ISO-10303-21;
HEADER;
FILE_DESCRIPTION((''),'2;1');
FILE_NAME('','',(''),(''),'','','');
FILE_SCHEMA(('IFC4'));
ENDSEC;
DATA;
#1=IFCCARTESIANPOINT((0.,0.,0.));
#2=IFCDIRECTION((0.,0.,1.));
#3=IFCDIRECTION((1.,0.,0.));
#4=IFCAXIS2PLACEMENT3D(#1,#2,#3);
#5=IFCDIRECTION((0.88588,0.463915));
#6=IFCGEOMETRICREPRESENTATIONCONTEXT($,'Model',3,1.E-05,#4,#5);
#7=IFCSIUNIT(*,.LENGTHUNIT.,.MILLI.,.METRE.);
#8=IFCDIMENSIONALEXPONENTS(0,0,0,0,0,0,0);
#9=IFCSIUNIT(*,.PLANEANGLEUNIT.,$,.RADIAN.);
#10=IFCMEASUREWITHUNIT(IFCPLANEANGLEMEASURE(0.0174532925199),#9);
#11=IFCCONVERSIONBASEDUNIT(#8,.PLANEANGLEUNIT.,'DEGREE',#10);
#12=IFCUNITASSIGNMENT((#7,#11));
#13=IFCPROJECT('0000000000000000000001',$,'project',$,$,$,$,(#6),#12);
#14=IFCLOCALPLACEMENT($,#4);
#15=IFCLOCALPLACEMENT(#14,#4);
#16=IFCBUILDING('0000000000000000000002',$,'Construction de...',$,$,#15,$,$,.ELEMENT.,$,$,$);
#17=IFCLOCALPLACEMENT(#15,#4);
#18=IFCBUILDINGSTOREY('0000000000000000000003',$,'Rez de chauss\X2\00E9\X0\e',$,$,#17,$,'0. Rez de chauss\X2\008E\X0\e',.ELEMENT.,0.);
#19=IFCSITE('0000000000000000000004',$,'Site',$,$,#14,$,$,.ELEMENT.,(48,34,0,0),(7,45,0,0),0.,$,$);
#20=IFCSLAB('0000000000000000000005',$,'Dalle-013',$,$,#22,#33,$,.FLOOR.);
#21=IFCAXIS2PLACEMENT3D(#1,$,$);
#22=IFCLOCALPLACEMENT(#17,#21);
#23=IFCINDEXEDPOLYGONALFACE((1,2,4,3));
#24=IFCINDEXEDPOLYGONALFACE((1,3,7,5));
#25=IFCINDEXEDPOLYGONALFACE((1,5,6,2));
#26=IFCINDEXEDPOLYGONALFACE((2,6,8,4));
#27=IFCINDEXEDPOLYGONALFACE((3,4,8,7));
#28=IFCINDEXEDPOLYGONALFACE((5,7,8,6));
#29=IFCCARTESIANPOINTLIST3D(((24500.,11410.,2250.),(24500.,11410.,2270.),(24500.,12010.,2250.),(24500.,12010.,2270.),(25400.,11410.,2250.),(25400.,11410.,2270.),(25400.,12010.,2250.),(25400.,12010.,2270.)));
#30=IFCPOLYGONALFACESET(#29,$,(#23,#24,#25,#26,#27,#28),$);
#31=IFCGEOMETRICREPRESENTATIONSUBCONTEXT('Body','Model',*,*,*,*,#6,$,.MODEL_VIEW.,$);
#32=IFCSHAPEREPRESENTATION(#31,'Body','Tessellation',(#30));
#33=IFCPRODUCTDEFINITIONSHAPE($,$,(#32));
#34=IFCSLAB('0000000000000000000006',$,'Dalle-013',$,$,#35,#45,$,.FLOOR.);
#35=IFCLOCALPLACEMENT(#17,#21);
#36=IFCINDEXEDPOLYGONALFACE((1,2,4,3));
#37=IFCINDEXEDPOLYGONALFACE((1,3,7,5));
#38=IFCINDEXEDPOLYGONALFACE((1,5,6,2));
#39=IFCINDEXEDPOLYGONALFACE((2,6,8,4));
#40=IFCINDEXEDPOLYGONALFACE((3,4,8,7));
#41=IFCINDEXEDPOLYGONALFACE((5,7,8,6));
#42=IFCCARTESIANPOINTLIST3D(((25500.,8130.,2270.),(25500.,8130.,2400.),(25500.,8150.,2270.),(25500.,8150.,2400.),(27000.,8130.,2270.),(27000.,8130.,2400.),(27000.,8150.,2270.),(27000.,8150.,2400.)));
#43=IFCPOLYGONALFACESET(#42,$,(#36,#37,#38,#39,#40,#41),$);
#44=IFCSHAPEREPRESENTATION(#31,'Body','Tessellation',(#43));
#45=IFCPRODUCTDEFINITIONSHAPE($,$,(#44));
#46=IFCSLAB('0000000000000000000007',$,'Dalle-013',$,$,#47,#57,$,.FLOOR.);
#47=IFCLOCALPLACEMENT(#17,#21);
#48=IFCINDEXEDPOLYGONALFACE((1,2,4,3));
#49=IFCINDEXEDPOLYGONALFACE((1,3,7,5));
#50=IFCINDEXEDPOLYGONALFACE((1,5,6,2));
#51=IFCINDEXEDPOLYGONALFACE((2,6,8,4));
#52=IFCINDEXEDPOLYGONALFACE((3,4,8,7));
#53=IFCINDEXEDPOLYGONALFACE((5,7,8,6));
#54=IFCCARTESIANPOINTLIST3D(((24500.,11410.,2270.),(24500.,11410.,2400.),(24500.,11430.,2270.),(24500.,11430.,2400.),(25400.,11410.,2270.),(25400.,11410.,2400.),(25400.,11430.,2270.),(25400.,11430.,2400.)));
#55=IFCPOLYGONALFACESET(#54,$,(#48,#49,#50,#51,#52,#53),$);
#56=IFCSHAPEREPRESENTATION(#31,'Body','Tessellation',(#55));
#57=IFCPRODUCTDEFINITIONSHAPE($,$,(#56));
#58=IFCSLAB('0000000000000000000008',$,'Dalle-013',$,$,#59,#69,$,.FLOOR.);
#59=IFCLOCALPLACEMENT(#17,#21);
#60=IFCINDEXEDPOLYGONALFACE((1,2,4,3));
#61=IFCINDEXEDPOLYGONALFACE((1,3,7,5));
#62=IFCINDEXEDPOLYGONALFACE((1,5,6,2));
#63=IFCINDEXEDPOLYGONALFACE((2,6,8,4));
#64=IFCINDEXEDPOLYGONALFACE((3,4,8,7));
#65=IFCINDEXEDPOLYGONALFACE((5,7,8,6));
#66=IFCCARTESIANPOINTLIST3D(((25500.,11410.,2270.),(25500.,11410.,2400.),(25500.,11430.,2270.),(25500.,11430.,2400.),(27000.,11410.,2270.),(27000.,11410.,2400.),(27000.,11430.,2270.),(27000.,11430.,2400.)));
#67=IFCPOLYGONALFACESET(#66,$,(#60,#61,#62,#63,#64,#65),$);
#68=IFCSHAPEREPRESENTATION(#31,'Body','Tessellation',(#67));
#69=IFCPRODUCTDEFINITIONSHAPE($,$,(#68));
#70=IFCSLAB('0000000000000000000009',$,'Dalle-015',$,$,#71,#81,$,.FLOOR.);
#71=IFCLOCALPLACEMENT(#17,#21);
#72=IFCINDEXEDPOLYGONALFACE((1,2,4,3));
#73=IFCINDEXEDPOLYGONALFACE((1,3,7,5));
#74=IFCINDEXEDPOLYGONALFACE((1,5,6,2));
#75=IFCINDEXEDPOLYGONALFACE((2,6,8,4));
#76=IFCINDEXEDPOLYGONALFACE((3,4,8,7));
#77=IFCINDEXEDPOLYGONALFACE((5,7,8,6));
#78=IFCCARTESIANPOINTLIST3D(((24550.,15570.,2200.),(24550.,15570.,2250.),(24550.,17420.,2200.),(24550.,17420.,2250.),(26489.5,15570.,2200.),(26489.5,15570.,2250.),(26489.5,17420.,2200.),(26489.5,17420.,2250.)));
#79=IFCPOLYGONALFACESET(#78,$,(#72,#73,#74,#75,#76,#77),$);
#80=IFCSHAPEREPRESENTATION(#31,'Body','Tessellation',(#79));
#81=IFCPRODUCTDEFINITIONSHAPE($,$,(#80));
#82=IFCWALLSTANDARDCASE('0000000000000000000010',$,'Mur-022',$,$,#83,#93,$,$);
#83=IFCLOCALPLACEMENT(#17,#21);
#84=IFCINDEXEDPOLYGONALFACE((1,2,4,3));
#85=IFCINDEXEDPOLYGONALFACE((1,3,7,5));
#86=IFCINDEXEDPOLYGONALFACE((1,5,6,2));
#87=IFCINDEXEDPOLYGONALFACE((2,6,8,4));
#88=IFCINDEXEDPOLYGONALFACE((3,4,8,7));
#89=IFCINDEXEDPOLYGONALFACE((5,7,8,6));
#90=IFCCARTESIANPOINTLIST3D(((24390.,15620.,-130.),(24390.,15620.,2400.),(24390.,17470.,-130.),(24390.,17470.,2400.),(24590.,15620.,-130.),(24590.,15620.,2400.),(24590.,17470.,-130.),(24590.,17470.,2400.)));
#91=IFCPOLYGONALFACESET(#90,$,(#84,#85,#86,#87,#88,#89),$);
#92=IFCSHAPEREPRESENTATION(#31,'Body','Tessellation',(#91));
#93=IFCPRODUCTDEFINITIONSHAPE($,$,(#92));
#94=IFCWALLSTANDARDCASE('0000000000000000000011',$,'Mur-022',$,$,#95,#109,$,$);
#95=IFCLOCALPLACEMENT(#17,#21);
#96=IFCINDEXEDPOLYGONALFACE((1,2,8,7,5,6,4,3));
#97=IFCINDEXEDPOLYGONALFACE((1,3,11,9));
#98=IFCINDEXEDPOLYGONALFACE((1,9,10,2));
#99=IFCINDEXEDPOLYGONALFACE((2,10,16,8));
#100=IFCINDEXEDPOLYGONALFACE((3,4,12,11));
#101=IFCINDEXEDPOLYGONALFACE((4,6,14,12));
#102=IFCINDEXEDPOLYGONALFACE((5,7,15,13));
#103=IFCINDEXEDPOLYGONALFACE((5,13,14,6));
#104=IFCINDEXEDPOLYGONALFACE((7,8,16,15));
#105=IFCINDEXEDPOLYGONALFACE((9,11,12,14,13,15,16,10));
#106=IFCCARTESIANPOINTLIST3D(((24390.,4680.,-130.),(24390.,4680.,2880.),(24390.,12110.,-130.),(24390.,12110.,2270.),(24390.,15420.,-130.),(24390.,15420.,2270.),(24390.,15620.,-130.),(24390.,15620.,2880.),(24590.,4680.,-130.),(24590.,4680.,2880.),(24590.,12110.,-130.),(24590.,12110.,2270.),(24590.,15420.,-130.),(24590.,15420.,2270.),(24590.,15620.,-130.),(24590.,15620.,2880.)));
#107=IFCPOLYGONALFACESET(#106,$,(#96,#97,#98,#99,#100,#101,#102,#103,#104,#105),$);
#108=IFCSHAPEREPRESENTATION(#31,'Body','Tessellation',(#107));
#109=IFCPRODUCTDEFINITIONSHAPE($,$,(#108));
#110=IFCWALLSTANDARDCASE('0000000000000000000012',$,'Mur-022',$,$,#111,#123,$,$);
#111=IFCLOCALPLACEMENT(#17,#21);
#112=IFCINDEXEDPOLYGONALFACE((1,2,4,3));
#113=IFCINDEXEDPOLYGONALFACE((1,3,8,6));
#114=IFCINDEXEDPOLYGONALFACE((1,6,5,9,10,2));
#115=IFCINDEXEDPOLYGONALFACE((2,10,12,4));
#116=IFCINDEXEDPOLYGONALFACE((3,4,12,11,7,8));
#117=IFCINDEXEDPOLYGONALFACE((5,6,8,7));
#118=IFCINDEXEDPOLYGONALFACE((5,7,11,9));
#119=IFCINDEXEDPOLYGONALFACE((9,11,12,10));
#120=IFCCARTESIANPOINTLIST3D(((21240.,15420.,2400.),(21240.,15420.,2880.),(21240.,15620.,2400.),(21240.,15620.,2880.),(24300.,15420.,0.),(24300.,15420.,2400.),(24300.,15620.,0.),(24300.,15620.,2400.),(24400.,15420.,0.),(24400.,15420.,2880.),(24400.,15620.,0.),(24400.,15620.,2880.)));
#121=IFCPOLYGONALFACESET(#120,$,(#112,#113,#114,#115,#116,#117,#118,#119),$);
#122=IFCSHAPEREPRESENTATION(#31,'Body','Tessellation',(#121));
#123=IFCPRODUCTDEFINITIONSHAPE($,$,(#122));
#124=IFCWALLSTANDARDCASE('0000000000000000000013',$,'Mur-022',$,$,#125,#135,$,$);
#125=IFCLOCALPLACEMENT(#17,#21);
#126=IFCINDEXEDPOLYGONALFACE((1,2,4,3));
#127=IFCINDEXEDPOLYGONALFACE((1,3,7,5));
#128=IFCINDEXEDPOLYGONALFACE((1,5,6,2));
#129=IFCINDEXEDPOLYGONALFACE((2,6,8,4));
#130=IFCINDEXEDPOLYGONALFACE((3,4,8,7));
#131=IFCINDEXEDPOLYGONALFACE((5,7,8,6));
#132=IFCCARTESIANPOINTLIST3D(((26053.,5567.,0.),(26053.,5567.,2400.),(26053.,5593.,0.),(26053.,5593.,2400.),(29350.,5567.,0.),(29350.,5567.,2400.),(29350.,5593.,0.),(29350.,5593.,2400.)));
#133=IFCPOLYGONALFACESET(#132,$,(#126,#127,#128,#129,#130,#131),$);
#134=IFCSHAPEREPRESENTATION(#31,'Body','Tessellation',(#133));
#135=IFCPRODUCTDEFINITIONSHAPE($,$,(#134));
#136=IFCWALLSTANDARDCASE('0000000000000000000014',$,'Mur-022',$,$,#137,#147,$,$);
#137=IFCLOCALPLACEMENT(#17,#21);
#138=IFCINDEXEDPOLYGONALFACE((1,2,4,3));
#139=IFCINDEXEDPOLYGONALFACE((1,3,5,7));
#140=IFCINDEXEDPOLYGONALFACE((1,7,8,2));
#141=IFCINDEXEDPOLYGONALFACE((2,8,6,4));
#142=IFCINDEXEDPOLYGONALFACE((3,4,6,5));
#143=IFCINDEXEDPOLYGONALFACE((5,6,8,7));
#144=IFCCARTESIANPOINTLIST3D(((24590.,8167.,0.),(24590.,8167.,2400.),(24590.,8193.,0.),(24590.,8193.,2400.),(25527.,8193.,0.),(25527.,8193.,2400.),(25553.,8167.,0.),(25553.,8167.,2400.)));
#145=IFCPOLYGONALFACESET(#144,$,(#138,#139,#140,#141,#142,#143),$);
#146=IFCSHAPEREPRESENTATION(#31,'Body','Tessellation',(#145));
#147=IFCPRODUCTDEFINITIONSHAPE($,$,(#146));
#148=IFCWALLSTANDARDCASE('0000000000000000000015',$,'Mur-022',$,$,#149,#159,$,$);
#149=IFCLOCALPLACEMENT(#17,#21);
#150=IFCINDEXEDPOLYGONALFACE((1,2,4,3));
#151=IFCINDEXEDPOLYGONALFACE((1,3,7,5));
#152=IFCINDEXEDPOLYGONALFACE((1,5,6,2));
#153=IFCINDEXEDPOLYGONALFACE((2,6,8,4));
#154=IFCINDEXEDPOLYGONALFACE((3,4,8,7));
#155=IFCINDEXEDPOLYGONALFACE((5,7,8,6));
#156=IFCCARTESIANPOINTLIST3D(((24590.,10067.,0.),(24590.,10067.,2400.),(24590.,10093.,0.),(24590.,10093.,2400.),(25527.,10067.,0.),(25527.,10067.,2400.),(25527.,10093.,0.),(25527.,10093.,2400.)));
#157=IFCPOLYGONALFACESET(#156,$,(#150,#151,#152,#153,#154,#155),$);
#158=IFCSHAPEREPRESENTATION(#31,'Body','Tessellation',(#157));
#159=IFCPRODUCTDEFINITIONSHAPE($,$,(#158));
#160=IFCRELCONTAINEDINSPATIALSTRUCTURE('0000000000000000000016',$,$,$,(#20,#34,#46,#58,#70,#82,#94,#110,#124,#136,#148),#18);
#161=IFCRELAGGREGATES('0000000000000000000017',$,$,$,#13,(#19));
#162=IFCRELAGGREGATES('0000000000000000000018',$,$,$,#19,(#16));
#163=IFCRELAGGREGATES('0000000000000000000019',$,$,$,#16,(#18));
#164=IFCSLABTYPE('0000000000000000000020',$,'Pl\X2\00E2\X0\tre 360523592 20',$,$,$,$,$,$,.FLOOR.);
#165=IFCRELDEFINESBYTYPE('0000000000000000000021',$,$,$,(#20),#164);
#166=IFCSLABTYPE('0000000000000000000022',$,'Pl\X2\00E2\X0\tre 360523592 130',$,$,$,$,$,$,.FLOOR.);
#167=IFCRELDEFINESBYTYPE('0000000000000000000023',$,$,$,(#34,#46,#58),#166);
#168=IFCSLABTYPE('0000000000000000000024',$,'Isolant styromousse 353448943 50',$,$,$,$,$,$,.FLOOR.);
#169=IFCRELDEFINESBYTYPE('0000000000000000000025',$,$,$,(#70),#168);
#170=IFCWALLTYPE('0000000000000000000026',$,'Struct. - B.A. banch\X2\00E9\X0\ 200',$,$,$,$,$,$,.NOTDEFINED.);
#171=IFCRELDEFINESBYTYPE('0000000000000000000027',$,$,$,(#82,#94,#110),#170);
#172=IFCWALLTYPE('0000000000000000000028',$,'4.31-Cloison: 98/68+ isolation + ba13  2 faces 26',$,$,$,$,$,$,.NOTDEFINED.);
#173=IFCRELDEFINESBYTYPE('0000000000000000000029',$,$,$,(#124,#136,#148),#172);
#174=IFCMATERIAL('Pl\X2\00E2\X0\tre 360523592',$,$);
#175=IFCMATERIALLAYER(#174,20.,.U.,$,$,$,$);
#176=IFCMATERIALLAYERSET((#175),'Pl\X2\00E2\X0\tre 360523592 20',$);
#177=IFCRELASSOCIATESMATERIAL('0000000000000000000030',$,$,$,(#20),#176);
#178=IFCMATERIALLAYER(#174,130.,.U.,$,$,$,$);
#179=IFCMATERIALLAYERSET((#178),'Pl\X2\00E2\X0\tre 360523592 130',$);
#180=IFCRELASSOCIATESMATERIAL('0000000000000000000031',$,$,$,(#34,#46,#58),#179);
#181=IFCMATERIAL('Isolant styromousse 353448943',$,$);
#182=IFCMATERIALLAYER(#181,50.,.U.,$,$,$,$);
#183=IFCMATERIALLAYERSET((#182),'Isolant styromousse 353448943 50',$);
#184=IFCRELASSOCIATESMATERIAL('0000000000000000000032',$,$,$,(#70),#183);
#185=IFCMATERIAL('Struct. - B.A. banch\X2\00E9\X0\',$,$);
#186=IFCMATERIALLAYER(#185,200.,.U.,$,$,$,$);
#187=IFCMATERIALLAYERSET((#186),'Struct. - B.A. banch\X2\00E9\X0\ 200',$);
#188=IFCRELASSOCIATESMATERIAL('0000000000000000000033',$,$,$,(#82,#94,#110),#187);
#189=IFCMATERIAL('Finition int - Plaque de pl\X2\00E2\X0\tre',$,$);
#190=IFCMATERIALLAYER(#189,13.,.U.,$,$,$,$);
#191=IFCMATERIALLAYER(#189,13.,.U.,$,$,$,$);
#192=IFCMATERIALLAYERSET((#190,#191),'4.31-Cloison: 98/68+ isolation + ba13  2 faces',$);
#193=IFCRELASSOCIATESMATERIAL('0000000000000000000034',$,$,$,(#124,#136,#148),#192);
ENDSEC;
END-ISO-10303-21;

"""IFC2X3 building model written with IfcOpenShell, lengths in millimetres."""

from ifc_helpers import new_model, entity, si_unit, converted_unit, direction, frame, origin_with_axes, origin_2d_with_axis, place, context, subcontext, project, spatial, polyline, rectangle, outline, extrude, material, layer, layer_set, layer_usage, type_object, element, save


model = new_model("IFC2X3")

# Units and contexts
model_context = context("Model", 3, precision=1e-05, world=origin_with_axes(), true_north=direction((0.88588, 0.463915)))
body_context = subcontext(model_context, "Body", "Model", "MODEL_VIEW")
ifc_project = project(units=[si_unit("LENGTHUNIT", "METRE", prefix="MILLI"), converted_unit("PLANEANGLEUNIT", "DEGREE", entity("IfcPlaneAngleMeasure", 0.0174532925199), si_unit("PLANEANGLEUNIT", "RADIAN"), dimensions=[0, 0, 0, 0, 0, 0, 0])], contexts=[model_context])

# Site, building, storey
site_placement = place(None, origin_with_axes())
site = spatial("IfcSite", under=ifc_project, at=site_placement, Name="Site", CompositionType="ELEMENT", RefLatitude=(48, 34, 0, 0), RefLongitude=(7, 45, 0, 0), RefElevation=0.0)
building_placement = place(site_placement, origin_with_axes())
building = spatial("IfcBuilding", under=site, at=building_placement, Name="Construction de...", CompositionType="ELEMENT")
storey_placement = place(building_placement, origin_with_axes())
storey = spatial("IfcBuildingStorey", under=building, at=storey_placement, Name="Rez de chaussée", LongName="0. Rez de chauss\u008ee", CompositionType="ELEMENT", Elevation=0.0)

# Shared definitions
ifc_material_1 = material(Name="Plâtre 360523592")
ifc_layer_1 = layer(ifc_material_1, 20.0, ventilated="UNKNOWN")
ifc_layer_set_1 = layer_set([ifc_layer_1], Name="Plâtre 360523592 20")
slab_type_1 = type_object("IfcSlabType", Name="Plâtre 360523592 20", PredefinedType="FLOOR")

# Slabs
ifc_layer_usage_1 = layer_usage(ifc_layer_set_1, "AXIS3", "NEGATIVE", 20.0)
slab_1_placement = place(storey_placement, frame((25400.0, 12010.0, 2270.0), z_axis=(0.0, 0.0, 1.0), x_axis=(1.0, 0.0, 0.0)))
element("IfcSlab", 1, at=slab_1_placement, inside=storey, type_object=slab_type_1, material=ifc_layer_usage_1, Name="Dalle-013", PredefinedType="FLOOR", context=body_context, shape_type="SweptSolid", body=[
    extrude(outline(polyline([(0.0, 0.0), (-900.0, 0.0), (-900.0, -600.0), (0.0, -600.0), (0.0, 0.0)])), frame((0.0, 0.0, -20.0), z_axis=(0.0, 0.0, 1.0), x_axis=(1.0, 0.0, 0.0)), (0.0, 0.0, 1.0), 20.0),
])
ifc_layer_2 = layer(ifc_material_1, 130.0, ventilated="UNKNOWN")
ifc_layer_set_2 = layer_set([ifc_layer_2], Name="Plâtre 360523592 130")
ifc_layer_usage_2 = layer_usage(ifc_layer_set_2, "AXIS3", "NEGATIVE", 130.0)
slab_type_2 = type_object("IfcSlabType", Name="Plâtre 360523592 130", PredefinedType="FLOOR")
slab_2_placement = place(storey_placement, frame((25500.0, 8150.0, 2400.0), z_axis=(0.0, 0.0, 1.0), x_axis=(1.0, 0.0, 0.0)))
element("IfcSlab", 2, at=slab_2_placement, inside=storey, type_object=slab_type_2, material=ifc_layer_usage_2, Name="Dalle-013", PredefinedType="FLOOR", context=body_context, shape_type="SweptSolid", body=[
    extrude(outline(polyline([(0.0, 0.0), (0.0, -20.0), (1500.0, -20.0), (1500.0, 0.0), (0.0, 0.0)])), frame((0.0, 0.0, -130.0), z_axis=(0.0, 0.0, 1.0), x_axis=(1.0, 0.0, 0.0)), (0.0, 0.0, 1.0), 130.0),
])
ifc_layer_usage_3 = layer_usage(ifc_layer_set_2, "AXIS3", "NEGATIVE", 130.0)
slab_3_placement = place(storey_placement, frame((24500.0, 11430.0, 2400.0), z_axis=(0.0, 0.0, 1.0), x_axis=(1.0, 0.0, 0.0)))
element("IfcSlab", 3, at=slab_3_placement, inside=storey, type_object=slab_type_2, material=ifc_layer_usage_3, Name="Dalle-013", PredefinedType="FLOOR", context=body_context, shape_type="SweptSolid", body=[
    extrude(outline(polyline([(0.0, 0.0), (0.0, -20.0), (900.0, -20.0), (900.0, 0.0), (0.0, 0.0)])), frame((0.0, 0.0, -130.0), z_axis=(0.0, 0.0, 1.0), x_axis=(1.0, 0.0, 0.0)), (0.0, 0.0, 1.0), 130.0),
])
ifc_layer_usage_4 = layer_usage(ifc_layer_set_2, "AXIS3", "NEGATIVE", 130.0)
slab_4_placement = place(storey_placement, frame((25500.0, 11430.0, 2400.0), z_axis=(0.0, 0.0, 1.0), x_axis=(1.0, 0.0, 0.0)))
element("IfcSlab", 4, at=slab_4_placement, inside=storey, type_object=slab_type_2, material=ifc_layer_usage_4, Name="Dalle-013", PredefinedType="FLOOR", context=body_context, shape_type="SweptSolid", body=[
    extrude(outline(polyline([(0.0, 0.0), (0.0, -20.0), (1500.0, -20.0), (1500.0, 0.0), (0.0, 0.0)])), frame((0.0, 0.0, -130.0), z_axis=(0.0, 0.0, 1.0), x_axis=(1.0, 0.0, 0.0)), (0.0, 0.0, 1.0), 130.0),
])
ifc_material_2 = material(Name="Isolant styromousse 353448943")
ifc_layer_3 = layer(ifc_material_2, 50.0, ventilated="UNKNOWN")
ifc_layer_set_3 = layer_set([ifc_layer_3], Name="Isolant styromousse 353448943 50")
ifc_layer_usage_5 = layer_usage(ifc_layer_set_3, "AXIS3", "NEGATIVE", 50.0)
slab_type_3 = type_object("IfcSlabType", Name="Isolant styromousse 353448943 50", PredefinedType="FLOOR")
slab_5_placement = place(storey_placement, frame((24550.0, 17420.0, 2250.0), z_axis=(0.0, 0.0, 1.0), x_axis=(1.0, 0.0, 0.0)))
element("IfcSlab", 5, at=slab_5_placement, inside=storey, type_object=slab_type_3, material=ifc_layer_usage_5, Name="Dalle-015", PredefinedType="FLOOR", context=body_context, shape_type="SweptSolid", body=[
    extrude(outline(polyline([(0.0, 0.0), (0.0, -1850.0), (1939.5, -1850.0), (1939.5, 0.0), (0.0, 0.0)])), frame((0.0, 0.0, -50.0), z_axis=(0.0, 0.0, 1.0), x_axis=(1.0, 0.0, 0.0)), (0.0, 0.0, 1.0), 50.0),
])

# Wall
ifc_material_3 = material(Name="Struct. - B.A. banché")
ifc_layer_4 = layer(ifc_material_3, 200.0, ventilated="UNKNOWN")
ifc_layer_set_4 = layer_set([ifc_layer_4], Name="Struct. - B.A. banché 200")
ifc_layer_usage_6 = layer_usage(ifc_layer_set_4, "AXIS2", "POSITIVE", -100.0)
wall_type_1 = type_object("IfcWallType", Name="Struct. - B.A. banché 200", PredefinedType="NOTDEFINED")
wall_1_placement = place(storey_placement, frame((24490.0, 17470.0, -130.0), z_axis=(0.0, 0.0, 1.0), x_axis=(0.0, -1.0, 0.0)))
element("IfcWallStandardCase", 6, at=wall_1_placement, inside=storey, type_object=wall_type_1, material=ifc_layer_usage_6, Name="Mur-022", context=body_context, shape_type="SweptSolid", body=[
    extrude(outline(polyline([(0.0, -100.0), (1850.0, -100.0), (1850.0, 100.0), (0.0, 100.0), (0.0, -100.0)])), origin_with_axes(), (0.0, 0.0, 1.0), 2530.0),
])

# Walls, openings
ifc_layer_usage_7 = layer_usage(ifc_layer_set_4, "AXIS2", "POSITIVE", -100.0)
wall_2_placement = place(storey_placement, frame((24490.0, 15620.0, -130.0), z_axis=(0.0, 0.0, 1.0), x_axis=(0.0, -1.0, 0.0)))
wall_2 = element("IfcWallStandardCase", 7, at=wall_2_placement, inside=storey, type_object=wall_type_1, material=ifc_layer_usage_7, Name="Mur-022", context=body_context, shape_type="SweptSolid", body=[
    extrude(outline(polyline([(0.0, -100.0), (10940.0, -100.0), (10940.0, 100.0), (0.0, 100.0), (0.0, -100.0)])), origin_with_axes(), (0.0, 0.0, 1.0), 3010.0),
])
opening_1_placement = place(wall_2_placement, frame((1855.0, 0.0, 0.0), z_axis=(0.0, 0.0, 1.0), x_axis=(1.0, 0.0, 0.0)))
element("IfcOpeningElement", 8, at=opening_1_placement, cuts=wall_2, context=body_context, shape_type="SweptSolid", body=[
    extrude(rectangle(XDim=3310.0, YDim=2400.0, at=origin_2d_with_axis()), frame((0.0, -100.0, 1200.0), z_axis=(0.0, 1.0, 0.0), x_axis=(1.0, 0.0, 0.0)), (0.0, 0.0, -1.0), 200.0),
    extrude(rectangle(XDim=3310.0, YDim=2400.0, at=origin_2d_with_axis()), frame((0.0, -100.0, 1200.0), z_axis=(0.0, -1.0, 0.0), x_axis=(1.0, 0.0, 0.0)), (0.0, 0.0, -1.0), 200.0),
])
ifc_layer_usage_8 = layer_usage(ifc_layer_set_4, "AXIS2", "POSITIVE", -100.0)
wall_3_placement = place(storey_placement, frame((24400.0, 15520.0, 0.0), z_axis=(0.0, 0.0, 1.0), x_axis=(-1.0, 0.0, 0.0)))
wall_3 = element("IfcWallStandardCase", 9, at=wall_3_placement, inside=storey, type_object=wall_type_1, material=ifc_layer_usage_8, Name="Mur-022", context=body_context, shape_type="SweptSolid", body=[
    extrude(outline(polyline([(0.0, -100.0), (3160.0, -100.0), (3160.0, 100.0), (0.0, 100.0), (0.0, -100.0)])), origin_with_axes(), (0.0, 0.0, 1.0), 2880.0),
])
opening_2_placement = place(wall_3_placement, frame((1630.0, 0.0, 0.0), z_axis=(0.0, 0.0, 1.0), x_axis=(1.0, 0.0, 0.0)))
element("IfcOpeningElement", 10, at=opening_2_placement, cuts=wall_3, context=body_context, shape_type="SweptSolid", body=[
    extrude(rectangle(XDim=3060.0, YDim=2400.0, at=origin_2d_with_axis()), frame((0.0, -100.0, 1200.0), z_axis=(0.0, 1.0, 0.0), x_axis=(1.0, 0.0, 0.0)), (0.0, 0.0, -1.0), 200.0),
    extrude(rectangle(XDim=3060.0, YDim=2400.0, at=origin_2d_with_axis()), frame((0.0, -100.0, 1200.0), z_axis=(0.0, -1.0, 0.0), x_axis=(1.0, 0.0, 0.0)), (0.0, 0.0, -1.0), 200.0),
])

# Walls
ifc_material_4 = material(Name="Finition int - Plaque de plâtre")
ifc_layer_5 = layer(ifc_material_4, 13.0, ventilated="UNKNOWN")
ifc_layer_6 = layer(ifc_material_4, 13.0, ventilated="UNKNOWN")
ifc_layer_set_5 = layer_set([ifc_layer_5, ifc_layer_6], Name="4.31-Cloison: 98/68+ isolation + ba13  2 faces")
ifc_layer_usage_9 = layer_usage(ifc_layer_set_5, "AXIS2", "POSITIVE", -13.0)
wall_type_2 = type_object("IfcWallType", Name="4.31-Cloison: 98/68+ isolation + ba13  2 faces 26", PredefinedType="NOTDEFINED")
wall_4_placement = place(storey_placement, frame((26040.0, 5580.0, 0.0), z_axis=(0.0, 0.0, 1.0), x_axis=(1.0, 0.0, 0.0)))
element("IfcWallStandardCase", 11, at=wall_4_placement, inside=storey, type_object=wall_type_2, material=ifc_layer_usage_9, Name="Mur-022", context=body_context, shape_type="SweptSolid", body=[
    extrude(outline(polyline([(13.0, -13.0), (3310.0, -13.0), (3310.0, 13.0), (13.0, 13.0), (13.0, -13.0)])), origin_with_axes(), (0.0, 0.0, 1.0), 2400.0),
])
ifc_layer_usage_10 = layer_usage(ifc_layer_set_5, "AXIS2", "POSITIVE", -13.0)
wall_5_placement = place(storey_placement, frame((25540.0, 8180.0, 0.0), z_axis=(0.0, 0.0, 1.0), x_axis=(-1.0, 0.0, 0.0)))
element("IfcWallStandardCase", 12, at=wall_5_placement, inside=storey, type_object=wall_type_2, material=ifc_layer_usage_10, Name="Mur-022", context=body_context, shape_type="SweptSolid", body=[
    extrude(outline(polyline([(13.0, -13.0), (950.0, -13.0), (950.0, 13.0), (-13.0, 13.0), (13.0, -13.0)])), origin_with_axes(), (0.0, 0.0, 1.0), 2400.0),
])
ifc_layer_usage_11 = layer_usage(ifc_layer_set_5, "AXIS2", "POSITIVE", -13.0)
wall_6_placement = place(storey_placement, frame((25540.0, 10080.0, 0.0), z_axis=(0.0, 0.0, 1.0), x_axis=(-1.0, 0.0, 0.0)))
element("IfcWallStandardCase", 13, at=wall_6_placement, inside=storey, type_object=wall_type_2, material=ifc_layer_usage_11, Name="Mur-022", context=body_context, shape_type="SweptSolid", body=[
    extrude(outline(polyline([(13.0, -13.0), (950.0, -13.0), (950.0, 13.0), (13.0, 13.0), (13.0, -13.0)])), origin_with_axes(), (0.0, 0.0, 1.0), 2400.0),
])

save(model, "model.ifc")
